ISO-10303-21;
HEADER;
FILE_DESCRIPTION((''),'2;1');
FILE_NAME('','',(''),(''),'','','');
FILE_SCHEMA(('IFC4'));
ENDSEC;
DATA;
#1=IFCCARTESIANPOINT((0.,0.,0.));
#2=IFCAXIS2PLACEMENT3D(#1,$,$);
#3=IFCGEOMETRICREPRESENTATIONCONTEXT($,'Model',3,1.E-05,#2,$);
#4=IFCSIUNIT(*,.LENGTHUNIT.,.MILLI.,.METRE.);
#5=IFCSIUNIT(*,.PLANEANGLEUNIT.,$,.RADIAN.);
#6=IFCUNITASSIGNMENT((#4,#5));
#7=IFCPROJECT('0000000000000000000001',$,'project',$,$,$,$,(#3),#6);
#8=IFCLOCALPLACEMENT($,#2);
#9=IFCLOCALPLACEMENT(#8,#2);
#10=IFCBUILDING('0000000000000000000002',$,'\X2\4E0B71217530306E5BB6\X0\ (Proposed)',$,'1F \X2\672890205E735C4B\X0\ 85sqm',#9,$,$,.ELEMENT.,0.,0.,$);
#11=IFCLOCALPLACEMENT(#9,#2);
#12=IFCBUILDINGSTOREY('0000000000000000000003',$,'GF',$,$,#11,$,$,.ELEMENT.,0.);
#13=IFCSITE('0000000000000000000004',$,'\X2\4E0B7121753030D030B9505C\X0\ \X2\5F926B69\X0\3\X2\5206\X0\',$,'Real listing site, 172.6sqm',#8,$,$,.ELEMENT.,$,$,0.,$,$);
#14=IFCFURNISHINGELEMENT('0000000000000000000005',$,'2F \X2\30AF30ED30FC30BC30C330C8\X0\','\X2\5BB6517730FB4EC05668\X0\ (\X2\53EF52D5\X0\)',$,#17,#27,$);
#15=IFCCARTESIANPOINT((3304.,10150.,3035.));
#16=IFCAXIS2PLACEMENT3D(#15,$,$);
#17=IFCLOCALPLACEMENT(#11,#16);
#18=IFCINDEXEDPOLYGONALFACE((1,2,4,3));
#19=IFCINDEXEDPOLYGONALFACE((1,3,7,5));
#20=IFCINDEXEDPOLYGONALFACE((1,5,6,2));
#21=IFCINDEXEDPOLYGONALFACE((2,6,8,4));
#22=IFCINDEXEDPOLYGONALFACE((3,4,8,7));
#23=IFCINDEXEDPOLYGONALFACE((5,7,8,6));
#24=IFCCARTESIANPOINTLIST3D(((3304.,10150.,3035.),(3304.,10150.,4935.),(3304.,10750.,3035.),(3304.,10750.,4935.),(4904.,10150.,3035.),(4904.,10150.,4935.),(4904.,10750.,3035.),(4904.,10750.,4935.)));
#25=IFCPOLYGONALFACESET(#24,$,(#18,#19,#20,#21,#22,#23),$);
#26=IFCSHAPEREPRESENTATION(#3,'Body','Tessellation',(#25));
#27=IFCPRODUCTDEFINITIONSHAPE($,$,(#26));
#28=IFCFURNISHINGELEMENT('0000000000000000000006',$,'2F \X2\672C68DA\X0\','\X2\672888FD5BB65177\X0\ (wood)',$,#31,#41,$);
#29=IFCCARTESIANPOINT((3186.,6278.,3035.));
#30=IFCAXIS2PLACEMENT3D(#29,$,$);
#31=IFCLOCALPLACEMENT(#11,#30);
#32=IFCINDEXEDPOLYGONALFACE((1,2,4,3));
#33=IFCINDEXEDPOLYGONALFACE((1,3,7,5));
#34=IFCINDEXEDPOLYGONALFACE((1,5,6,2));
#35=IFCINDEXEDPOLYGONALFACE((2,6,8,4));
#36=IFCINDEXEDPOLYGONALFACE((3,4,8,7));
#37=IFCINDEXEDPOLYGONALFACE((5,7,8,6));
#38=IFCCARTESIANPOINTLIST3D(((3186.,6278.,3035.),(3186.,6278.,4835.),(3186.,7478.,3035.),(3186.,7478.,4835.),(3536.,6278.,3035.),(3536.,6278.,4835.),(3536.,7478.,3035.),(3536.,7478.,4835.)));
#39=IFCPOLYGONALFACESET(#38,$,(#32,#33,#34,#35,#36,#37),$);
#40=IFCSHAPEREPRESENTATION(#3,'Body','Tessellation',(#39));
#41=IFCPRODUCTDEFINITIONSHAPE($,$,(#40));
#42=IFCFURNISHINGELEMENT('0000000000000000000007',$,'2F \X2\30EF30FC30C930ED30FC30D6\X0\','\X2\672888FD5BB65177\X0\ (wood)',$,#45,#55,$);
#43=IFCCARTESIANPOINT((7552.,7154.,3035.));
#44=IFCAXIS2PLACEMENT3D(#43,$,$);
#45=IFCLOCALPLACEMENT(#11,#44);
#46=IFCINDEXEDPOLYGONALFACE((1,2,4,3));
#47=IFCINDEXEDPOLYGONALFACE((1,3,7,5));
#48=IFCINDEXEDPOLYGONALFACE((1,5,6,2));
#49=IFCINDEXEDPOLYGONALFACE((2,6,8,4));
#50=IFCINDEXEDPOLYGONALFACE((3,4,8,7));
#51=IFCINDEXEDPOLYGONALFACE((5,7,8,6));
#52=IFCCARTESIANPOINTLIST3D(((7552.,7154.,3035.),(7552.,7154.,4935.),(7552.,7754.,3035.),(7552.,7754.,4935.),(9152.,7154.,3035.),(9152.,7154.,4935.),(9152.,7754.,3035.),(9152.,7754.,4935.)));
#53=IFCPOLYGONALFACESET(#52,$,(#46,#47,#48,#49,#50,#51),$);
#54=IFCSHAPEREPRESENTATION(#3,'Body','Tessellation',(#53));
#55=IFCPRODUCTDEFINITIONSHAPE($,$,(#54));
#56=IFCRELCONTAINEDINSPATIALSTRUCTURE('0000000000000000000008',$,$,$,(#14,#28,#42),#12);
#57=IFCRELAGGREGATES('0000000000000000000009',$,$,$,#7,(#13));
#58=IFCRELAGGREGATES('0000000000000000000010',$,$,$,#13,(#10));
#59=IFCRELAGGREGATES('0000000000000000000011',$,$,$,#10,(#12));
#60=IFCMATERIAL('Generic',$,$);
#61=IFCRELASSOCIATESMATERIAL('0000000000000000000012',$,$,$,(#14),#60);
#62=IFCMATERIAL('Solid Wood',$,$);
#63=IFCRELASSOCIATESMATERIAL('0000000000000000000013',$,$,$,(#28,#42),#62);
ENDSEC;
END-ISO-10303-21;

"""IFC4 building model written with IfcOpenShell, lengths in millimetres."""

from ifc_helpers import new_model, si_unit, frame, frame_2d, origin, place, context, project, spatial, rectangle, extrude, material, element, save


model = new_model("IFC4")

# Units and contexts
model_context = context("Model", 3, precision=1e-05, world=origin())
ifc_project = project(units=[si_unit("LENGTHUNIT", "METRE", prefix="MILLI"), si_unit("PLANEANGLEUNIT", "RADIAN")], contexts=[model_context])

# Site, building, storey
site_placement = place(None, origin())
site = spatial("IfcSite", under=ifc_project, at=site_placement, Name="下無田バス停 徒歩3分", ObjectType="Real listing site, 172.6sqm", CompositionType="ELEMENT", RefElevation=0.0)
building_placement = place(site_placement, origin())
building = spatial("IfcBuilding", under=site, at=building_placement, Name="下無田の家 (Proposed)", ObjectType="1F 木造平屋 85sqm", CompositionType="ELEMENT", ElevationOfRefHeight=0.0, ElevationOfTerrain=0.0)
storey_placement = place(building_placement, origin())
storey = spatial("IfcBuildingStorey", under=building, at=storey_placement, Name="GF", CompositionType="ELEMENT", Elevation=0.0)

# Shared definitions
ifc_material_1 = material(Name="Solid Wood")

# Shared definitions
ifc_material_2 = material(Name="Generic")

# Furnishing elements
furnishing_1_placement = place(storey_placement, frame((3304.0, 10150.0, 3035.0)))
element("IfcFurnishingElement", 1, at=furnishing_1_placement, inside=storey, material=ifc_material_2, Name="2F クローゼット", Description="家具・什器 (可動)", context=model_context, shape_type="SweptSolid", body=[
    extrude(rectangle(XDim=1600.0, YDim=600.0, at=frame_2d((800.0, 300.0))), frame((3304.0, 10150.0, 3035.0)), (0.0, 0.0, 1.0), 1900.0),
])
furnishing_2_placement = place(storey_placement, frame((3186.0, 6278.0, 3035.0)))
element("IfcFurnishingElement", 2, at=furnishing_2_placement, inside=storey, material=ifc_material_1, Name="2F 本棚", Description="木製家具 (wood)", context=model_context, shape_type="SweptSolid", body=[
    extrude(rectangle(XDim=350.0, YDim=1200.0, at=frame_2d((175.0, 600.0))), frame((3186.0, 6278.0, 3035.0)), (0.0, 0.0, 1.0), 1800.0),
])
furnishing_3_placement = place(storey_placement, frame((7552.0, 7154.0, 3035.0)))
element("IfcFurnishingElement", 3, at=furnishing_3_placement, inside=storey, material=ifc_material_1, Name="2F ワードローブ", Description="木製家具 (wood)", context=model_context, shape_type="SweptSolid", body=[
    extrude(rectangle(XDim=1600.0, YDim=600.0, at=frame_2d((800.0, 300.0))), frame((7552.0, 7154.0, 3035.0)), (0.0, 0.0, 1.0), 1900.0),
])

save(model, "model.ifc")
